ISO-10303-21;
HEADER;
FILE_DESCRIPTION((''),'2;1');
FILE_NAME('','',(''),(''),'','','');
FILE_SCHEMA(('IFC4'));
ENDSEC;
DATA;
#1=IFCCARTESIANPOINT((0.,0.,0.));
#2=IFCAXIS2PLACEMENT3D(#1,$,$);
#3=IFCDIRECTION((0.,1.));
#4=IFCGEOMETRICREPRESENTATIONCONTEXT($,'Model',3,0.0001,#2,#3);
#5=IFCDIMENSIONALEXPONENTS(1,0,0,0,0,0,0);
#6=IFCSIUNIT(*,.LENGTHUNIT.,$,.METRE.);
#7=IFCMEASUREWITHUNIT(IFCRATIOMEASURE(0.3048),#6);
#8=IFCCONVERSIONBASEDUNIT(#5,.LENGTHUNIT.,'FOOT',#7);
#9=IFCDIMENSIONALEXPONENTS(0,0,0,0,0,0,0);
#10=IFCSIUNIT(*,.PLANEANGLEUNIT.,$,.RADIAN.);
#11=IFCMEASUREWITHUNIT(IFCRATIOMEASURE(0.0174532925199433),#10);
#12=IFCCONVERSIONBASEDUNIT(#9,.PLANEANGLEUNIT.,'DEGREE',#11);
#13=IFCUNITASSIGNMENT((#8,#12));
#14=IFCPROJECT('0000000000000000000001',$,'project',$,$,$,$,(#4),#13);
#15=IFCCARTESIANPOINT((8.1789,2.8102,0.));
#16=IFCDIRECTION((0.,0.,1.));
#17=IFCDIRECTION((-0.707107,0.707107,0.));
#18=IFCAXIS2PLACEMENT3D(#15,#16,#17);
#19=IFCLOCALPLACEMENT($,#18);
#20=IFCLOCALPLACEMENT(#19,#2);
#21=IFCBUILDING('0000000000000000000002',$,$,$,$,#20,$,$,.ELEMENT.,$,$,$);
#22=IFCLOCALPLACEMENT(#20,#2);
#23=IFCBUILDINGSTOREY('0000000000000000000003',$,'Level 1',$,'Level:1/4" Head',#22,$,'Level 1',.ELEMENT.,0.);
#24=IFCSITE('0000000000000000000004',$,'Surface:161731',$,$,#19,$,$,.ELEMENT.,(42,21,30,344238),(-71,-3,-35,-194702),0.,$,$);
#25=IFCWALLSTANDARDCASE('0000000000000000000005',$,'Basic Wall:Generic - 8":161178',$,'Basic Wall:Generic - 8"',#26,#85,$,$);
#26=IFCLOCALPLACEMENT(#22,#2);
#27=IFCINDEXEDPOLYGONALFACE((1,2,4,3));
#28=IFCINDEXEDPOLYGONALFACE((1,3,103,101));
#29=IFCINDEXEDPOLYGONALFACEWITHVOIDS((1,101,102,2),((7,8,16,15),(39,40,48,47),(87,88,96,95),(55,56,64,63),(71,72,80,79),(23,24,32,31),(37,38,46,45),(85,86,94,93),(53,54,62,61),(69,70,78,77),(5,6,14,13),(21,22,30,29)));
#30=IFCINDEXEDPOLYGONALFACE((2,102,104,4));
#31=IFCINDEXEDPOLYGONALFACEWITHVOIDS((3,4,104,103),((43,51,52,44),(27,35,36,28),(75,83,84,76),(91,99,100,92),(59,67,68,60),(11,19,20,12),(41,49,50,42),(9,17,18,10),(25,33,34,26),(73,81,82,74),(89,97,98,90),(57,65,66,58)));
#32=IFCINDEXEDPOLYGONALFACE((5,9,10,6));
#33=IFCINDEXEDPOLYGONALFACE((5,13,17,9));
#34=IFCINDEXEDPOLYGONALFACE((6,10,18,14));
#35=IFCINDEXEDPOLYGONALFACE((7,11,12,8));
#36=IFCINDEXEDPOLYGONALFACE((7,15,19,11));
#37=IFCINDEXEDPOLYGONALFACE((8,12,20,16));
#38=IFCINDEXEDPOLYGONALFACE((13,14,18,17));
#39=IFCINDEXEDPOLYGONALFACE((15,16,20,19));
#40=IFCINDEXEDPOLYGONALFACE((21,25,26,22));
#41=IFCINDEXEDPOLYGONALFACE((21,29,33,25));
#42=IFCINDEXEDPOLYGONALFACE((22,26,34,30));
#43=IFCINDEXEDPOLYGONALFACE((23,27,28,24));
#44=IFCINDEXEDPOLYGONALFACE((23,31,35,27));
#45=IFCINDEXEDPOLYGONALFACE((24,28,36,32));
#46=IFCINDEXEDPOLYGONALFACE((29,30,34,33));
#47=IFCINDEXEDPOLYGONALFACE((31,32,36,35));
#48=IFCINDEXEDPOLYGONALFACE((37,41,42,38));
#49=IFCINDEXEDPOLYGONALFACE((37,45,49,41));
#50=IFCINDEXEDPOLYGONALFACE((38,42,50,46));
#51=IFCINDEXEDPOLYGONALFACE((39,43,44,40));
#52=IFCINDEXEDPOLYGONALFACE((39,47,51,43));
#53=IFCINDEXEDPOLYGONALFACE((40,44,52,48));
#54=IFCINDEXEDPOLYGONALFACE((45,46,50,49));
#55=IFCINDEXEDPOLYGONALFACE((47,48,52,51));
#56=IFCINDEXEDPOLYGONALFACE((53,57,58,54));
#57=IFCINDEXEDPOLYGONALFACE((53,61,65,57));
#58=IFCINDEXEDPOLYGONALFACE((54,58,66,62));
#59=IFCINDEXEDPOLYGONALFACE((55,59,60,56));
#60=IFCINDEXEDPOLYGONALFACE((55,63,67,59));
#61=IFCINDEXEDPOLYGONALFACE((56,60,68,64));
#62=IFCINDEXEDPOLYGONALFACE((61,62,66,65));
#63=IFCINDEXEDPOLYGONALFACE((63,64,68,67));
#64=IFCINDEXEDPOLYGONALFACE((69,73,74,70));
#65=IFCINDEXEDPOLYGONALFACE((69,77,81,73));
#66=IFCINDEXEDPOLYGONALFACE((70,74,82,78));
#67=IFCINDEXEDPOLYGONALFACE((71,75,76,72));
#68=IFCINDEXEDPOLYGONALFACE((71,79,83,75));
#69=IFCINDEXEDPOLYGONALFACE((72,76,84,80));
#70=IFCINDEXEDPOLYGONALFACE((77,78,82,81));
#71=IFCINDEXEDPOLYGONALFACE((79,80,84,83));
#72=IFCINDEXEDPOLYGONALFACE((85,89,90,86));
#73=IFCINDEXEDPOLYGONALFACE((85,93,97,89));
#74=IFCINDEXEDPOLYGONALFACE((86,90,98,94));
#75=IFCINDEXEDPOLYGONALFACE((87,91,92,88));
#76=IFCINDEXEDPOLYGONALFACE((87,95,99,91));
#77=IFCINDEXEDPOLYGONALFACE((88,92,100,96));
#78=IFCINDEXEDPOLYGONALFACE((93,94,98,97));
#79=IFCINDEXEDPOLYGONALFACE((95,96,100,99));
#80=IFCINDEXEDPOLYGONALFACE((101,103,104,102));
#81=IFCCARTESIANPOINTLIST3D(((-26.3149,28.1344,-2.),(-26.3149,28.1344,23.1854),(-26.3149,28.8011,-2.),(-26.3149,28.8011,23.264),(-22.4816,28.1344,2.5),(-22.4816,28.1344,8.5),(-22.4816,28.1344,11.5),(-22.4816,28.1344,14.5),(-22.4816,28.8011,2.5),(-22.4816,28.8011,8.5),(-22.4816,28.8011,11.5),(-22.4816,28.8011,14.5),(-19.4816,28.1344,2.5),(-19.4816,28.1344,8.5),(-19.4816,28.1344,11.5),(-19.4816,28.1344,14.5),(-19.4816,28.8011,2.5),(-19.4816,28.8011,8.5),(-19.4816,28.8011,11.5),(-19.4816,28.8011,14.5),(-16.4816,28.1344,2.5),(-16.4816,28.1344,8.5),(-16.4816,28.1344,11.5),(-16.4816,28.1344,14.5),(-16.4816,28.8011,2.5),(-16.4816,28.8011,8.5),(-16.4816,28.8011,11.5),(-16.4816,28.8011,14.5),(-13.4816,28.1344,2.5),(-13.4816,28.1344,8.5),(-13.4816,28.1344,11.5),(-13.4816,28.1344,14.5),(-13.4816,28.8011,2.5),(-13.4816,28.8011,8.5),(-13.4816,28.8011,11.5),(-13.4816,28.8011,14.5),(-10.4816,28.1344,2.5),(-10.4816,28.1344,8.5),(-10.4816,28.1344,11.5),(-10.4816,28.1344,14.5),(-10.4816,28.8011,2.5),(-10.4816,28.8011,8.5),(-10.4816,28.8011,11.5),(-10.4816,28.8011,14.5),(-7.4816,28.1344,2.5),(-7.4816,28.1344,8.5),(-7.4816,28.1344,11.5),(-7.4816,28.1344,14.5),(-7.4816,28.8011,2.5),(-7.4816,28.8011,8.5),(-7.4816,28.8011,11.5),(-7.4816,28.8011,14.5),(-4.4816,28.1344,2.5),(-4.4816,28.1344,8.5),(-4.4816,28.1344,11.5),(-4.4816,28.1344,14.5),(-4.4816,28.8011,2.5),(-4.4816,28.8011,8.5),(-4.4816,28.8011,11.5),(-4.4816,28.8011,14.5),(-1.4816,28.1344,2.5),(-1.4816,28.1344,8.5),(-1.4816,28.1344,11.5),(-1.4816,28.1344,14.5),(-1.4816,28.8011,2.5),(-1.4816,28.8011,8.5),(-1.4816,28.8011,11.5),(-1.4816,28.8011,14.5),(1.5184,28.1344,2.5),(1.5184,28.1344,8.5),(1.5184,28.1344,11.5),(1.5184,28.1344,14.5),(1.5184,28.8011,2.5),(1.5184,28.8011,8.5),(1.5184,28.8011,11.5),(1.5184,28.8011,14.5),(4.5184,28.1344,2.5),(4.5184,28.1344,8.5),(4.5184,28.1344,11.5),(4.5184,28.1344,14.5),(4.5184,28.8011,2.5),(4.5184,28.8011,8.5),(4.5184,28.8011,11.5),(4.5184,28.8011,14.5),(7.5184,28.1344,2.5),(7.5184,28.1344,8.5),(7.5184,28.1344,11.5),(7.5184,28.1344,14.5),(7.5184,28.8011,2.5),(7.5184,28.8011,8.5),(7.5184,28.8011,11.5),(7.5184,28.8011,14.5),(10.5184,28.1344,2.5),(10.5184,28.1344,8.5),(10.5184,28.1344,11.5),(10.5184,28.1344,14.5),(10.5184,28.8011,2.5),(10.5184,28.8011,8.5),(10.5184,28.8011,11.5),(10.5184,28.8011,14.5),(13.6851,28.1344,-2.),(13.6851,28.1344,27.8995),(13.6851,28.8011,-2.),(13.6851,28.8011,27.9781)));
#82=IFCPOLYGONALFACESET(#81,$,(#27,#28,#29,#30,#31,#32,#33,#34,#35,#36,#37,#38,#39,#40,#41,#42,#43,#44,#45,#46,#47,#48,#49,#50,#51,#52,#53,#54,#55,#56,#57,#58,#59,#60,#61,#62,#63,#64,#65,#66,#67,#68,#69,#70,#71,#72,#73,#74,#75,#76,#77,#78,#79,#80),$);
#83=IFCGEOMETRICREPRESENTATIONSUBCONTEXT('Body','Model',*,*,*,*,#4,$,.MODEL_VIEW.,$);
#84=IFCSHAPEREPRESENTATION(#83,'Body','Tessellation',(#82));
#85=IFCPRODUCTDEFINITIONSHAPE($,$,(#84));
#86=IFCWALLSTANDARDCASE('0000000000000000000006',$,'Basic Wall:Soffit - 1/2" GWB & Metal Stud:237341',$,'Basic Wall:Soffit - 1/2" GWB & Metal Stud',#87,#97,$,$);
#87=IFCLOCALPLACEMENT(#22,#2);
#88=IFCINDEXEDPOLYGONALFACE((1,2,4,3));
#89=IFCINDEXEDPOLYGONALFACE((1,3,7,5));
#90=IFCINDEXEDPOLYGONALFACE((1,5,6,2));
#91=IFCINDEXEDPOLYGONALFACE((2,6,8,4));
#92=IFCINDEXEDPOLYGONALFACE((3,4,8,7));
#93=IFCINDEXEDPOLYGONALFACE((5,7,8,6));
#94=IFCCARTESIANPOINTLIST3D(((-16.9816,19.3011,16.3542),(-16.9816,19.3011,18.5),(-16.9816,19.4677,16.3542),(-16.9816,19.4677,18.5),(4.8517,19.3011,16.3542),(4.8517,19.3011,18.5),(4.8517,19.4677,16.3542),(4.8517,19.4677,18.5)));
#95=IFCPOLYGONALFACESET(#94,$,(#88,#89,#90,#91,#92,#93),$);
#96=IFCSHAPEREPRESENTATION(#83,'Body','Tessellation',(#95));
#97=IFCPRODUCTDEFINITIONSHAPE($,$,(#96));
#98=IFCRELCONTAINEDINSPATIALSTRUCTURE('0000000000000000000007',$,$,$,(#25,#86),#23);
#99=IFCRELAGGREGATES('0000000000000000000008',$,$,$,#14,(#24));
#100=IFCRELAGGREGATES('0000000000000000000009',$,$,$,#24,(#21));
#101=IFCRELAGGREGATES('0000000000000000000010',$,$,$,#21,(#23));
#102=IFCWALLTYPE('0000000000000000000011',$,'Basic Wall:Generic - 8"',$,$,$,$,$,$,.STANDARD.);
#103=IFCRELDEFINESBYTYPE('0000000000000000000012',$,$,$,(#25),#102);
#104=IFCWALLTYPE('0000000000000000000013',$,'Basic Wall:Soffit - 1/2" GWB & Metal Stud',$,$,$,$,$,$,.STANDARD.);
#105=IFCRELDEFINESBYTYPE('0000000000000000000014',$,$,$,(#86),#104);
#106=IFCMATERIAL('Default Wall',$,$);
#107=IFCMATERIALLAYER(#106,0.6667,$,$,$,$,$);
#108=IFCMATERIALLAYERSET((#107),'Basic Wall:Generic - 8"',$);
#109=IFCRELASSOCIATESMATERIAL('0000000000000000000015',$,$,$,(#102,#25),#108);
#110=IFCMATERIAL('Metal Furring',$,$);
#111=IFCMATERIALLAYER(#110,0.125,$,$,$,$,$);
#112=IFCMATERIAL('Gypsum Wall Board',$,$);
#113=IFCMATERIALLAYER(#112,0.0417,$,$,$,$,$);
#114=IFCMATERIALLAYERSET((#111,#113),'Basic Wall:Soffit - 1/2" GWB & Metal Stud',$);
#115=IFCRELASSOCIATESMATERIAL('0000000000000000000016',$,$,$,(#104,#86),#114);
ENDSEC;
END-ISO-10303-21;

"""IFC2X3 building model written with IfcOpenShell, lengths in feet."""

from ifc_helpers import new_model, entity, si_unit, converted_unit, direction, frame, frame_2d, origin, place, context, subcontext, project, spatial, polyline, rectangle, extrude, clip, bounded_halfspace, material, layer, layer_set, layer_usage, type_object, element, save


model = new_model("IFC2X3")

# Units and contexts
model_context = context("Model", 3, precision=0.0001, world=origin(), true_north=direction((0.0, 1.0)))
body_context = subcontext(model_context, "Body", "Model", "MODEL_VIEW")
ifc_project = project(units=[converted_unit("LENGTHUNIT", "FOOT", entity("IfcRatioMeasure", 0.3048), si_unit("LENGTHUNIT", "METRE"), dimensions=[1, 0, 0, 0, 0, 0, 0]), converted_unit("PLANEANGLEUNIT", "DEGREE", entity("IfcRatioMeasure", 0.0174532925199433), si_unit("PLANEANGLEUNIT", "RADIAN"), dimensions=[0, 0, 0, 0, 0, 0, 0])], contexts=[model_context])

# Site, building, storey
site_placement = place(None, frame((8.1789, 2.8102, 0.0), z_axis=(0.0, 0.0, 1.0), x_axis=(-0.707107, 0.707107, 0.0)))
site = spatial("IfcSite", under=ifc_project, at=site_placement, Name="Surface:161731", CompositionType="ELEMENT", RefLatitude=(42, 21, 30, 344238), RefLongitude=(-71, -3, -35, -194702), RefElevation=0.0)
building_placement = place(site_placement, origin())
building = spatial("IfcBuilding", under=site, at=building_placement, CompositionType="ELEMENT")
storey_placement = place(building_placement, origin())
storey = spatial("IfcBuildingStorey", under=building, at=storey_placement, Name="Level 1", ObjectType="Level:1/4\" Head", LongName="Level 1", CompositionType="ELEMENT", Elevation=0.0)

# Wall, openings
ifc_material_1 = material(Name="Default Wall")
ifc_layer_1 = layer(ifc_material_1, 0.6667)
ifc_layer_set_1 = layer_set([ifc_layer_1], Name="Basic Wall:Generic - 8\"")
ifc_layer_usage_1 = layer_usage(ifc_layer_set_1, "AXIS2", "NEGATIVE", 0.3333)
wall_type_1 = type_object("IfcWallType", Name="Basic Wall:Generic - 8\"", PredefinedType="STANDARD", material=ifc_layer_set_1)
wall_1_placement = place(storey_placement, frame((-26.3149, 28.4677, -2.0)))
wall_1 = element("IfcWallStandardCase", 1, at=wall_1_placement, inside=storey, type_object=wall_type_1, material=ifc_layer_usage_1, Name="Basic Wall:Generic - 8\":161178", ObjectType="Basic Wall:Generic - 8\"", context=body_context, shape_type="Clipping", body=[
    clip(extrude(rectangle(XDim=40.0, YDim=0.6667, at=frame_2d((20.0, 0.0), x_axis=(-1.0, 0.0))), origin(), (0.0, 0.0, 1.0), 29.9781), bounded_halfspace(frame((0.0, -0.3333, 25.1854), z_axis=(-0.116248, -0.116248, 0.986394), x_axis=(0.707107, -0.707107, 0.0)), False, frame((0.0, -0.3333, 25.1854)), polyline([(0.0, 0.0), (0.6667, 0.0), (40.0, 0.0), (40.0, 0.6667), (0.0, 0.6667), (0.0, 0.0)]))),
])
opening_1_placement = place(wall_1_placement, frame((9.8333, -0.3333, 4.5)))
element("IfcOpeningElement", 2, at=opening_1_placement, cuts=wall_1, ObjectType="Opening", context=body_context, shape_type="SweptSolid", body=[
    extrude(rectangle(XDim=6.0, YDim=3.0, at=frame_2d((3.0, 1.5), x_axis=(-1.0, 0.0))), frame((0.0, 0.0, 0.0), z_axis=(0.0, 1.0, 0.0), x_axis=(0.0, 0.0, 1.0)), (0.0, 0.0, 1.0), 0.6667),
])
opening_2_placement = place(wall_1_placement, frame((15.8333, -0.3333, 4.5)))
element("IfcOpeningElement", 3, at=opening_2_placement, cuts=wall_1, ObjectType="Opening", context=body_context, shape_type="SweptSolid", body=[
    extrude(rectangle(XDim=6.0, YDim=3.0, at=frame_2d((3.0, 1.5), x_axis=(-1.0, 0.0))), frame((0.0, 0.0, 0.0), z_axis=(0.0, 1.0, 0.0), x_axis=(0.0, 0.0, 1.0)), (0.0, 0.0, 1.0), 0.6667),
])
opening_3_placement = place(wall_1_placement, frame((21.8333, -0.3333, 4.5)))
element("IfcOpeningElement", 4, at=opening_3_placement, cuts=wall_1, ObjectType="Opening", context=body_context, shape_type="SweptSolid", body=[
    extrude(rectangle(XDim=6.0, YDim=3.0, at=frame_2d((3.0, 1.5), x_axis=(-1.0, 0.0))), frame((0.0, 0.0, 0.0), z_axis=(0.0, 1.0, 0.0), x_axis=(0.0, 0.0, 1.0)), (0.0, 0.0, 1.0), 0.6667),
])
opening_4_placement = place(wall_1_placement, frame((27.8333, -0.3333, 4.5)))
element("IfcOpeningElement", 5, at=opening_4_placement, cuts=wall_1, ObjectType="Opening", context=body_context, shape_type="SweptSolid", body=[
    extrude(rectangle(XDim=6.0, YDim=3.0, at=frame_2d((3.0, 1.5), x_axis=(-1.0, 0.0))), frame((0.0, 0.0, 0.0), z_axis=(0.0, 1.0, 0.0), x_axis=(0.0, 0.0, 1.0)), (0.0, 0.0, 1.0), 0.6667),
])
opening_5_placement = place(wall_1_placement, frame((33.8333, -0.3333, 4.5)))
element("IfcOpeningElement", 6, at=opening_5_placement, cuts=wall_1, ObjectType="Opening", context=body_context, shape_type="SweptSolid", body=[
    extrude(rectangle(XDim=6.0, YDim=3.0, at=frame_2d((3.0, 1.5), x_axis=(-1.0, 0.0))), frame((0.0, 0.0, 0.0), z_axis=(0.0, 1.0, 0.0), x_axis=(0.0, 0.0, 1.0)), (0.0, 0.0, 1.0), 0.6667),
])
opening_6_placement = place(wall_1_placement, frame((9.8333, -0.3333, 13.5)))
element("IfcOpeningElement", 7, at=opening_6_placement, cuts=wall_1, ObjectType="Opening", context=body_context, shape_type="SweptSolid", body=[
    extrude(rectangle(XDim=3.0, YDim=3.0, at=frame_2d((1.5, 1.5), x_axis=(-1.0, 0.0))), frame((0.0, 0.0, 0.0), z_axis=(0.0, 1.0, 0.0), x_axis=(0.0, 0.0, 1.0)), (0.0, 0.0, 1.0), 0.6667),
])
opening_7_placement = place(wall_1_placement, frame((15.8333, -0.3333, 13.5)))
element("IfcOpeningElement", 8, at=opening_7_placement, cuts=wall_1, ObjectType="Opening", context=body_context, shape_type="SweptSolid", body=[
    extrude(rectangle(XDim=3.0, YDim=3.0, at=frame_2d((1.5, 1.5), x_axis=(-1.0, 0.0))), frame((0.0, 0.0, 0.0), z_axis=(0.0, 1.0, 0.0), x_axis=(0.0, 0.0, 1.0)), (0.0, 0.0, 1.0), 0.6667),
])
opening_8_placement = place(wall_1_placement, frame((21.8333, -0.3333, 13.5)))
element("IfcOpeningElement", 9, at=opening_8_placement, cuts=wall_1, ObjectType="Opening", context=body_context, shape_type="SweptSolid", body=[
    extrude(rectangle(XDim=3.0, YDim=3.0, at=frame_2d((1.5, 1.5), x_axis=(-1.0, 0.0))), frame((0.0, 0.0, 0.0), z_axis=(0.0, 1.0, 0.0), x_axis=(0.0, 0.0, 1.0)), (0.0, 0.0, 1.0), 0.6667),
])
opening_9_placement = place(wall_1_placement, frame((27.8333, -0.3333, 13.5)))
element("IfcOpeningElement", 10, at=opening_9_placement, cuts=wall_1, ObjectType="Opening", context=body_context, shape_type="SweptSolid", body=[
    extrude(rectangle(XDim=3.0, YDim=3.0, at=frame_2d((1.5, 1.5), x_axis=(-1.0, 0.0))), frame((0.0, 0.0, 0.0), z_axis=(0.0, 1.0, 0.0), x_axis=(0.0, 0.0, 1.0)), (0.0, 0.0, 1.0), 0.6667),
])
opening_10_placement = place(wall_1_placement, frame((33.8333, -0.3333, 13.5)))
element("IfcOpeningElement", 11, at=opening_10_placement, cuts=wall_1, ObjectType="Opening", context=body_context, shape_type="SweptSolid", body=[
    extrude(rectangle(XDim=3.0, YDim=3.0, at=frame_2d((1.5, 1.5), x_axis=(-1.0, 0.0))), frame((0.0, 0.0, 0.0), z_axis=(0.0, 1.0, 0.0), x_axis=(0.0, 0.0, 1.0)), (0.0, 0.0, 1.0), 0.6667),
])
opening_11_placement = place(wall_1_placement, frame((3.8333, -0.3333, 4.5)))
element("IfcOpeningElement", 12, at=opening_11_placement, cuts=wall_1, ObjectType="Opening", context=body_context, shape_type="SweptSolid", body=[
    extrude(rectangle(XDim=6.0, YDim=3.0, at=frame_2d((3.0, 1.5), x_axis=(-1.0, 0.0))), frame((0.0, 0.0, 0.0), z_axis=(0.0, 1.0, 0.0), x_axis=(0.0, 0.0, 1.0)), (0.0, 0.0, 1.0), 0.6667),
])
opening_12_placement = place(wall_1_placement, frame((3.8333, -0.3333, 13.5)))
element("IfcOpeningElement", 13, at=opening_12_placement, cuts=wall_1, ObjectType="Opening", context=body_context, shape_type="SweptSolid", body=[
    extrude(rectangle(XDim=3.0, YDim=3.0, at=frame_2d((1.5, 1.5), x_axis=(-1.0, 0.0))), frame((0.0, 0.0, 0.0), z_axis=(0.0, 1.0, 0.0), x_axis=(0.0, 0.0, 1.0)), (0.0, 0.0, 1.0), 0.6667),
])

# Wall
ifc_material_2 = material(Name="Metal Furring")
ifc_layer_2 = layer(ifc_material_2, 0.125)
ifc_material_3 = material(Name="Gypsum Wall Board")
ifc_layer_3 = layer(ifc_material_3, 0.0417)
ifc_layer_set_2 = layer_set([ifc_layer_2, ifc_layer_3], Name="Basic Wall:Soffit - 1/2\" GWB & Metal Stud")
ifc_layer_usage_2 = layer_usage(ifc_layer_set_2, "AXIS2", "POSITIVE", -0.0833)
wall_type_2 = type_object("IfcWallType", Name="Basic Wall:Soffit - 1/2\" GWB & Metal Stud", PredefinedType="STANDARD", material=ifc_layer_set_2)
wall_2_placement = place(storey_placement, frame((-16.9816, 19.3844, 16.3542)))
element("IfcWallStandardCase", 14, at=wall_2_placement, inside=storey, type_object=wall_type_2, material=ifc_layer_usage_2, Name="Basic Wall:Soffit - 1/2\" GWB & Metal Stud:237341", ObjectType="Basic Wall:Soffit - 1/2\" GWB & Metal Stud", context=body_context, shape_type="Clipping", body=[
    clip(extrude(rectangle(XDim=21.8333, YDim=0.1667, at=frame_2d((10.9167, 0.0), x_axis=(-1.0, 0.0))), origin(), (0.0, 0.0, 1.0), 2.1458), bounded_halfspace(frame((21.8333, -0.0833, 0.0), z_axis=(0.0, 0.0, 1.0), x_axis=(0.0, -1.0, 0.0)), True, frame((21.8333, -0.0833, 0.0)), polyline([(0.0, 0.0), (0.0, 0.1667), (-21.8333, 0.1667), (-21.8333, 0.0), (-21.6667, 0.0), (0.0, 0.0)]))),
])

save(model, "model.ifc")
